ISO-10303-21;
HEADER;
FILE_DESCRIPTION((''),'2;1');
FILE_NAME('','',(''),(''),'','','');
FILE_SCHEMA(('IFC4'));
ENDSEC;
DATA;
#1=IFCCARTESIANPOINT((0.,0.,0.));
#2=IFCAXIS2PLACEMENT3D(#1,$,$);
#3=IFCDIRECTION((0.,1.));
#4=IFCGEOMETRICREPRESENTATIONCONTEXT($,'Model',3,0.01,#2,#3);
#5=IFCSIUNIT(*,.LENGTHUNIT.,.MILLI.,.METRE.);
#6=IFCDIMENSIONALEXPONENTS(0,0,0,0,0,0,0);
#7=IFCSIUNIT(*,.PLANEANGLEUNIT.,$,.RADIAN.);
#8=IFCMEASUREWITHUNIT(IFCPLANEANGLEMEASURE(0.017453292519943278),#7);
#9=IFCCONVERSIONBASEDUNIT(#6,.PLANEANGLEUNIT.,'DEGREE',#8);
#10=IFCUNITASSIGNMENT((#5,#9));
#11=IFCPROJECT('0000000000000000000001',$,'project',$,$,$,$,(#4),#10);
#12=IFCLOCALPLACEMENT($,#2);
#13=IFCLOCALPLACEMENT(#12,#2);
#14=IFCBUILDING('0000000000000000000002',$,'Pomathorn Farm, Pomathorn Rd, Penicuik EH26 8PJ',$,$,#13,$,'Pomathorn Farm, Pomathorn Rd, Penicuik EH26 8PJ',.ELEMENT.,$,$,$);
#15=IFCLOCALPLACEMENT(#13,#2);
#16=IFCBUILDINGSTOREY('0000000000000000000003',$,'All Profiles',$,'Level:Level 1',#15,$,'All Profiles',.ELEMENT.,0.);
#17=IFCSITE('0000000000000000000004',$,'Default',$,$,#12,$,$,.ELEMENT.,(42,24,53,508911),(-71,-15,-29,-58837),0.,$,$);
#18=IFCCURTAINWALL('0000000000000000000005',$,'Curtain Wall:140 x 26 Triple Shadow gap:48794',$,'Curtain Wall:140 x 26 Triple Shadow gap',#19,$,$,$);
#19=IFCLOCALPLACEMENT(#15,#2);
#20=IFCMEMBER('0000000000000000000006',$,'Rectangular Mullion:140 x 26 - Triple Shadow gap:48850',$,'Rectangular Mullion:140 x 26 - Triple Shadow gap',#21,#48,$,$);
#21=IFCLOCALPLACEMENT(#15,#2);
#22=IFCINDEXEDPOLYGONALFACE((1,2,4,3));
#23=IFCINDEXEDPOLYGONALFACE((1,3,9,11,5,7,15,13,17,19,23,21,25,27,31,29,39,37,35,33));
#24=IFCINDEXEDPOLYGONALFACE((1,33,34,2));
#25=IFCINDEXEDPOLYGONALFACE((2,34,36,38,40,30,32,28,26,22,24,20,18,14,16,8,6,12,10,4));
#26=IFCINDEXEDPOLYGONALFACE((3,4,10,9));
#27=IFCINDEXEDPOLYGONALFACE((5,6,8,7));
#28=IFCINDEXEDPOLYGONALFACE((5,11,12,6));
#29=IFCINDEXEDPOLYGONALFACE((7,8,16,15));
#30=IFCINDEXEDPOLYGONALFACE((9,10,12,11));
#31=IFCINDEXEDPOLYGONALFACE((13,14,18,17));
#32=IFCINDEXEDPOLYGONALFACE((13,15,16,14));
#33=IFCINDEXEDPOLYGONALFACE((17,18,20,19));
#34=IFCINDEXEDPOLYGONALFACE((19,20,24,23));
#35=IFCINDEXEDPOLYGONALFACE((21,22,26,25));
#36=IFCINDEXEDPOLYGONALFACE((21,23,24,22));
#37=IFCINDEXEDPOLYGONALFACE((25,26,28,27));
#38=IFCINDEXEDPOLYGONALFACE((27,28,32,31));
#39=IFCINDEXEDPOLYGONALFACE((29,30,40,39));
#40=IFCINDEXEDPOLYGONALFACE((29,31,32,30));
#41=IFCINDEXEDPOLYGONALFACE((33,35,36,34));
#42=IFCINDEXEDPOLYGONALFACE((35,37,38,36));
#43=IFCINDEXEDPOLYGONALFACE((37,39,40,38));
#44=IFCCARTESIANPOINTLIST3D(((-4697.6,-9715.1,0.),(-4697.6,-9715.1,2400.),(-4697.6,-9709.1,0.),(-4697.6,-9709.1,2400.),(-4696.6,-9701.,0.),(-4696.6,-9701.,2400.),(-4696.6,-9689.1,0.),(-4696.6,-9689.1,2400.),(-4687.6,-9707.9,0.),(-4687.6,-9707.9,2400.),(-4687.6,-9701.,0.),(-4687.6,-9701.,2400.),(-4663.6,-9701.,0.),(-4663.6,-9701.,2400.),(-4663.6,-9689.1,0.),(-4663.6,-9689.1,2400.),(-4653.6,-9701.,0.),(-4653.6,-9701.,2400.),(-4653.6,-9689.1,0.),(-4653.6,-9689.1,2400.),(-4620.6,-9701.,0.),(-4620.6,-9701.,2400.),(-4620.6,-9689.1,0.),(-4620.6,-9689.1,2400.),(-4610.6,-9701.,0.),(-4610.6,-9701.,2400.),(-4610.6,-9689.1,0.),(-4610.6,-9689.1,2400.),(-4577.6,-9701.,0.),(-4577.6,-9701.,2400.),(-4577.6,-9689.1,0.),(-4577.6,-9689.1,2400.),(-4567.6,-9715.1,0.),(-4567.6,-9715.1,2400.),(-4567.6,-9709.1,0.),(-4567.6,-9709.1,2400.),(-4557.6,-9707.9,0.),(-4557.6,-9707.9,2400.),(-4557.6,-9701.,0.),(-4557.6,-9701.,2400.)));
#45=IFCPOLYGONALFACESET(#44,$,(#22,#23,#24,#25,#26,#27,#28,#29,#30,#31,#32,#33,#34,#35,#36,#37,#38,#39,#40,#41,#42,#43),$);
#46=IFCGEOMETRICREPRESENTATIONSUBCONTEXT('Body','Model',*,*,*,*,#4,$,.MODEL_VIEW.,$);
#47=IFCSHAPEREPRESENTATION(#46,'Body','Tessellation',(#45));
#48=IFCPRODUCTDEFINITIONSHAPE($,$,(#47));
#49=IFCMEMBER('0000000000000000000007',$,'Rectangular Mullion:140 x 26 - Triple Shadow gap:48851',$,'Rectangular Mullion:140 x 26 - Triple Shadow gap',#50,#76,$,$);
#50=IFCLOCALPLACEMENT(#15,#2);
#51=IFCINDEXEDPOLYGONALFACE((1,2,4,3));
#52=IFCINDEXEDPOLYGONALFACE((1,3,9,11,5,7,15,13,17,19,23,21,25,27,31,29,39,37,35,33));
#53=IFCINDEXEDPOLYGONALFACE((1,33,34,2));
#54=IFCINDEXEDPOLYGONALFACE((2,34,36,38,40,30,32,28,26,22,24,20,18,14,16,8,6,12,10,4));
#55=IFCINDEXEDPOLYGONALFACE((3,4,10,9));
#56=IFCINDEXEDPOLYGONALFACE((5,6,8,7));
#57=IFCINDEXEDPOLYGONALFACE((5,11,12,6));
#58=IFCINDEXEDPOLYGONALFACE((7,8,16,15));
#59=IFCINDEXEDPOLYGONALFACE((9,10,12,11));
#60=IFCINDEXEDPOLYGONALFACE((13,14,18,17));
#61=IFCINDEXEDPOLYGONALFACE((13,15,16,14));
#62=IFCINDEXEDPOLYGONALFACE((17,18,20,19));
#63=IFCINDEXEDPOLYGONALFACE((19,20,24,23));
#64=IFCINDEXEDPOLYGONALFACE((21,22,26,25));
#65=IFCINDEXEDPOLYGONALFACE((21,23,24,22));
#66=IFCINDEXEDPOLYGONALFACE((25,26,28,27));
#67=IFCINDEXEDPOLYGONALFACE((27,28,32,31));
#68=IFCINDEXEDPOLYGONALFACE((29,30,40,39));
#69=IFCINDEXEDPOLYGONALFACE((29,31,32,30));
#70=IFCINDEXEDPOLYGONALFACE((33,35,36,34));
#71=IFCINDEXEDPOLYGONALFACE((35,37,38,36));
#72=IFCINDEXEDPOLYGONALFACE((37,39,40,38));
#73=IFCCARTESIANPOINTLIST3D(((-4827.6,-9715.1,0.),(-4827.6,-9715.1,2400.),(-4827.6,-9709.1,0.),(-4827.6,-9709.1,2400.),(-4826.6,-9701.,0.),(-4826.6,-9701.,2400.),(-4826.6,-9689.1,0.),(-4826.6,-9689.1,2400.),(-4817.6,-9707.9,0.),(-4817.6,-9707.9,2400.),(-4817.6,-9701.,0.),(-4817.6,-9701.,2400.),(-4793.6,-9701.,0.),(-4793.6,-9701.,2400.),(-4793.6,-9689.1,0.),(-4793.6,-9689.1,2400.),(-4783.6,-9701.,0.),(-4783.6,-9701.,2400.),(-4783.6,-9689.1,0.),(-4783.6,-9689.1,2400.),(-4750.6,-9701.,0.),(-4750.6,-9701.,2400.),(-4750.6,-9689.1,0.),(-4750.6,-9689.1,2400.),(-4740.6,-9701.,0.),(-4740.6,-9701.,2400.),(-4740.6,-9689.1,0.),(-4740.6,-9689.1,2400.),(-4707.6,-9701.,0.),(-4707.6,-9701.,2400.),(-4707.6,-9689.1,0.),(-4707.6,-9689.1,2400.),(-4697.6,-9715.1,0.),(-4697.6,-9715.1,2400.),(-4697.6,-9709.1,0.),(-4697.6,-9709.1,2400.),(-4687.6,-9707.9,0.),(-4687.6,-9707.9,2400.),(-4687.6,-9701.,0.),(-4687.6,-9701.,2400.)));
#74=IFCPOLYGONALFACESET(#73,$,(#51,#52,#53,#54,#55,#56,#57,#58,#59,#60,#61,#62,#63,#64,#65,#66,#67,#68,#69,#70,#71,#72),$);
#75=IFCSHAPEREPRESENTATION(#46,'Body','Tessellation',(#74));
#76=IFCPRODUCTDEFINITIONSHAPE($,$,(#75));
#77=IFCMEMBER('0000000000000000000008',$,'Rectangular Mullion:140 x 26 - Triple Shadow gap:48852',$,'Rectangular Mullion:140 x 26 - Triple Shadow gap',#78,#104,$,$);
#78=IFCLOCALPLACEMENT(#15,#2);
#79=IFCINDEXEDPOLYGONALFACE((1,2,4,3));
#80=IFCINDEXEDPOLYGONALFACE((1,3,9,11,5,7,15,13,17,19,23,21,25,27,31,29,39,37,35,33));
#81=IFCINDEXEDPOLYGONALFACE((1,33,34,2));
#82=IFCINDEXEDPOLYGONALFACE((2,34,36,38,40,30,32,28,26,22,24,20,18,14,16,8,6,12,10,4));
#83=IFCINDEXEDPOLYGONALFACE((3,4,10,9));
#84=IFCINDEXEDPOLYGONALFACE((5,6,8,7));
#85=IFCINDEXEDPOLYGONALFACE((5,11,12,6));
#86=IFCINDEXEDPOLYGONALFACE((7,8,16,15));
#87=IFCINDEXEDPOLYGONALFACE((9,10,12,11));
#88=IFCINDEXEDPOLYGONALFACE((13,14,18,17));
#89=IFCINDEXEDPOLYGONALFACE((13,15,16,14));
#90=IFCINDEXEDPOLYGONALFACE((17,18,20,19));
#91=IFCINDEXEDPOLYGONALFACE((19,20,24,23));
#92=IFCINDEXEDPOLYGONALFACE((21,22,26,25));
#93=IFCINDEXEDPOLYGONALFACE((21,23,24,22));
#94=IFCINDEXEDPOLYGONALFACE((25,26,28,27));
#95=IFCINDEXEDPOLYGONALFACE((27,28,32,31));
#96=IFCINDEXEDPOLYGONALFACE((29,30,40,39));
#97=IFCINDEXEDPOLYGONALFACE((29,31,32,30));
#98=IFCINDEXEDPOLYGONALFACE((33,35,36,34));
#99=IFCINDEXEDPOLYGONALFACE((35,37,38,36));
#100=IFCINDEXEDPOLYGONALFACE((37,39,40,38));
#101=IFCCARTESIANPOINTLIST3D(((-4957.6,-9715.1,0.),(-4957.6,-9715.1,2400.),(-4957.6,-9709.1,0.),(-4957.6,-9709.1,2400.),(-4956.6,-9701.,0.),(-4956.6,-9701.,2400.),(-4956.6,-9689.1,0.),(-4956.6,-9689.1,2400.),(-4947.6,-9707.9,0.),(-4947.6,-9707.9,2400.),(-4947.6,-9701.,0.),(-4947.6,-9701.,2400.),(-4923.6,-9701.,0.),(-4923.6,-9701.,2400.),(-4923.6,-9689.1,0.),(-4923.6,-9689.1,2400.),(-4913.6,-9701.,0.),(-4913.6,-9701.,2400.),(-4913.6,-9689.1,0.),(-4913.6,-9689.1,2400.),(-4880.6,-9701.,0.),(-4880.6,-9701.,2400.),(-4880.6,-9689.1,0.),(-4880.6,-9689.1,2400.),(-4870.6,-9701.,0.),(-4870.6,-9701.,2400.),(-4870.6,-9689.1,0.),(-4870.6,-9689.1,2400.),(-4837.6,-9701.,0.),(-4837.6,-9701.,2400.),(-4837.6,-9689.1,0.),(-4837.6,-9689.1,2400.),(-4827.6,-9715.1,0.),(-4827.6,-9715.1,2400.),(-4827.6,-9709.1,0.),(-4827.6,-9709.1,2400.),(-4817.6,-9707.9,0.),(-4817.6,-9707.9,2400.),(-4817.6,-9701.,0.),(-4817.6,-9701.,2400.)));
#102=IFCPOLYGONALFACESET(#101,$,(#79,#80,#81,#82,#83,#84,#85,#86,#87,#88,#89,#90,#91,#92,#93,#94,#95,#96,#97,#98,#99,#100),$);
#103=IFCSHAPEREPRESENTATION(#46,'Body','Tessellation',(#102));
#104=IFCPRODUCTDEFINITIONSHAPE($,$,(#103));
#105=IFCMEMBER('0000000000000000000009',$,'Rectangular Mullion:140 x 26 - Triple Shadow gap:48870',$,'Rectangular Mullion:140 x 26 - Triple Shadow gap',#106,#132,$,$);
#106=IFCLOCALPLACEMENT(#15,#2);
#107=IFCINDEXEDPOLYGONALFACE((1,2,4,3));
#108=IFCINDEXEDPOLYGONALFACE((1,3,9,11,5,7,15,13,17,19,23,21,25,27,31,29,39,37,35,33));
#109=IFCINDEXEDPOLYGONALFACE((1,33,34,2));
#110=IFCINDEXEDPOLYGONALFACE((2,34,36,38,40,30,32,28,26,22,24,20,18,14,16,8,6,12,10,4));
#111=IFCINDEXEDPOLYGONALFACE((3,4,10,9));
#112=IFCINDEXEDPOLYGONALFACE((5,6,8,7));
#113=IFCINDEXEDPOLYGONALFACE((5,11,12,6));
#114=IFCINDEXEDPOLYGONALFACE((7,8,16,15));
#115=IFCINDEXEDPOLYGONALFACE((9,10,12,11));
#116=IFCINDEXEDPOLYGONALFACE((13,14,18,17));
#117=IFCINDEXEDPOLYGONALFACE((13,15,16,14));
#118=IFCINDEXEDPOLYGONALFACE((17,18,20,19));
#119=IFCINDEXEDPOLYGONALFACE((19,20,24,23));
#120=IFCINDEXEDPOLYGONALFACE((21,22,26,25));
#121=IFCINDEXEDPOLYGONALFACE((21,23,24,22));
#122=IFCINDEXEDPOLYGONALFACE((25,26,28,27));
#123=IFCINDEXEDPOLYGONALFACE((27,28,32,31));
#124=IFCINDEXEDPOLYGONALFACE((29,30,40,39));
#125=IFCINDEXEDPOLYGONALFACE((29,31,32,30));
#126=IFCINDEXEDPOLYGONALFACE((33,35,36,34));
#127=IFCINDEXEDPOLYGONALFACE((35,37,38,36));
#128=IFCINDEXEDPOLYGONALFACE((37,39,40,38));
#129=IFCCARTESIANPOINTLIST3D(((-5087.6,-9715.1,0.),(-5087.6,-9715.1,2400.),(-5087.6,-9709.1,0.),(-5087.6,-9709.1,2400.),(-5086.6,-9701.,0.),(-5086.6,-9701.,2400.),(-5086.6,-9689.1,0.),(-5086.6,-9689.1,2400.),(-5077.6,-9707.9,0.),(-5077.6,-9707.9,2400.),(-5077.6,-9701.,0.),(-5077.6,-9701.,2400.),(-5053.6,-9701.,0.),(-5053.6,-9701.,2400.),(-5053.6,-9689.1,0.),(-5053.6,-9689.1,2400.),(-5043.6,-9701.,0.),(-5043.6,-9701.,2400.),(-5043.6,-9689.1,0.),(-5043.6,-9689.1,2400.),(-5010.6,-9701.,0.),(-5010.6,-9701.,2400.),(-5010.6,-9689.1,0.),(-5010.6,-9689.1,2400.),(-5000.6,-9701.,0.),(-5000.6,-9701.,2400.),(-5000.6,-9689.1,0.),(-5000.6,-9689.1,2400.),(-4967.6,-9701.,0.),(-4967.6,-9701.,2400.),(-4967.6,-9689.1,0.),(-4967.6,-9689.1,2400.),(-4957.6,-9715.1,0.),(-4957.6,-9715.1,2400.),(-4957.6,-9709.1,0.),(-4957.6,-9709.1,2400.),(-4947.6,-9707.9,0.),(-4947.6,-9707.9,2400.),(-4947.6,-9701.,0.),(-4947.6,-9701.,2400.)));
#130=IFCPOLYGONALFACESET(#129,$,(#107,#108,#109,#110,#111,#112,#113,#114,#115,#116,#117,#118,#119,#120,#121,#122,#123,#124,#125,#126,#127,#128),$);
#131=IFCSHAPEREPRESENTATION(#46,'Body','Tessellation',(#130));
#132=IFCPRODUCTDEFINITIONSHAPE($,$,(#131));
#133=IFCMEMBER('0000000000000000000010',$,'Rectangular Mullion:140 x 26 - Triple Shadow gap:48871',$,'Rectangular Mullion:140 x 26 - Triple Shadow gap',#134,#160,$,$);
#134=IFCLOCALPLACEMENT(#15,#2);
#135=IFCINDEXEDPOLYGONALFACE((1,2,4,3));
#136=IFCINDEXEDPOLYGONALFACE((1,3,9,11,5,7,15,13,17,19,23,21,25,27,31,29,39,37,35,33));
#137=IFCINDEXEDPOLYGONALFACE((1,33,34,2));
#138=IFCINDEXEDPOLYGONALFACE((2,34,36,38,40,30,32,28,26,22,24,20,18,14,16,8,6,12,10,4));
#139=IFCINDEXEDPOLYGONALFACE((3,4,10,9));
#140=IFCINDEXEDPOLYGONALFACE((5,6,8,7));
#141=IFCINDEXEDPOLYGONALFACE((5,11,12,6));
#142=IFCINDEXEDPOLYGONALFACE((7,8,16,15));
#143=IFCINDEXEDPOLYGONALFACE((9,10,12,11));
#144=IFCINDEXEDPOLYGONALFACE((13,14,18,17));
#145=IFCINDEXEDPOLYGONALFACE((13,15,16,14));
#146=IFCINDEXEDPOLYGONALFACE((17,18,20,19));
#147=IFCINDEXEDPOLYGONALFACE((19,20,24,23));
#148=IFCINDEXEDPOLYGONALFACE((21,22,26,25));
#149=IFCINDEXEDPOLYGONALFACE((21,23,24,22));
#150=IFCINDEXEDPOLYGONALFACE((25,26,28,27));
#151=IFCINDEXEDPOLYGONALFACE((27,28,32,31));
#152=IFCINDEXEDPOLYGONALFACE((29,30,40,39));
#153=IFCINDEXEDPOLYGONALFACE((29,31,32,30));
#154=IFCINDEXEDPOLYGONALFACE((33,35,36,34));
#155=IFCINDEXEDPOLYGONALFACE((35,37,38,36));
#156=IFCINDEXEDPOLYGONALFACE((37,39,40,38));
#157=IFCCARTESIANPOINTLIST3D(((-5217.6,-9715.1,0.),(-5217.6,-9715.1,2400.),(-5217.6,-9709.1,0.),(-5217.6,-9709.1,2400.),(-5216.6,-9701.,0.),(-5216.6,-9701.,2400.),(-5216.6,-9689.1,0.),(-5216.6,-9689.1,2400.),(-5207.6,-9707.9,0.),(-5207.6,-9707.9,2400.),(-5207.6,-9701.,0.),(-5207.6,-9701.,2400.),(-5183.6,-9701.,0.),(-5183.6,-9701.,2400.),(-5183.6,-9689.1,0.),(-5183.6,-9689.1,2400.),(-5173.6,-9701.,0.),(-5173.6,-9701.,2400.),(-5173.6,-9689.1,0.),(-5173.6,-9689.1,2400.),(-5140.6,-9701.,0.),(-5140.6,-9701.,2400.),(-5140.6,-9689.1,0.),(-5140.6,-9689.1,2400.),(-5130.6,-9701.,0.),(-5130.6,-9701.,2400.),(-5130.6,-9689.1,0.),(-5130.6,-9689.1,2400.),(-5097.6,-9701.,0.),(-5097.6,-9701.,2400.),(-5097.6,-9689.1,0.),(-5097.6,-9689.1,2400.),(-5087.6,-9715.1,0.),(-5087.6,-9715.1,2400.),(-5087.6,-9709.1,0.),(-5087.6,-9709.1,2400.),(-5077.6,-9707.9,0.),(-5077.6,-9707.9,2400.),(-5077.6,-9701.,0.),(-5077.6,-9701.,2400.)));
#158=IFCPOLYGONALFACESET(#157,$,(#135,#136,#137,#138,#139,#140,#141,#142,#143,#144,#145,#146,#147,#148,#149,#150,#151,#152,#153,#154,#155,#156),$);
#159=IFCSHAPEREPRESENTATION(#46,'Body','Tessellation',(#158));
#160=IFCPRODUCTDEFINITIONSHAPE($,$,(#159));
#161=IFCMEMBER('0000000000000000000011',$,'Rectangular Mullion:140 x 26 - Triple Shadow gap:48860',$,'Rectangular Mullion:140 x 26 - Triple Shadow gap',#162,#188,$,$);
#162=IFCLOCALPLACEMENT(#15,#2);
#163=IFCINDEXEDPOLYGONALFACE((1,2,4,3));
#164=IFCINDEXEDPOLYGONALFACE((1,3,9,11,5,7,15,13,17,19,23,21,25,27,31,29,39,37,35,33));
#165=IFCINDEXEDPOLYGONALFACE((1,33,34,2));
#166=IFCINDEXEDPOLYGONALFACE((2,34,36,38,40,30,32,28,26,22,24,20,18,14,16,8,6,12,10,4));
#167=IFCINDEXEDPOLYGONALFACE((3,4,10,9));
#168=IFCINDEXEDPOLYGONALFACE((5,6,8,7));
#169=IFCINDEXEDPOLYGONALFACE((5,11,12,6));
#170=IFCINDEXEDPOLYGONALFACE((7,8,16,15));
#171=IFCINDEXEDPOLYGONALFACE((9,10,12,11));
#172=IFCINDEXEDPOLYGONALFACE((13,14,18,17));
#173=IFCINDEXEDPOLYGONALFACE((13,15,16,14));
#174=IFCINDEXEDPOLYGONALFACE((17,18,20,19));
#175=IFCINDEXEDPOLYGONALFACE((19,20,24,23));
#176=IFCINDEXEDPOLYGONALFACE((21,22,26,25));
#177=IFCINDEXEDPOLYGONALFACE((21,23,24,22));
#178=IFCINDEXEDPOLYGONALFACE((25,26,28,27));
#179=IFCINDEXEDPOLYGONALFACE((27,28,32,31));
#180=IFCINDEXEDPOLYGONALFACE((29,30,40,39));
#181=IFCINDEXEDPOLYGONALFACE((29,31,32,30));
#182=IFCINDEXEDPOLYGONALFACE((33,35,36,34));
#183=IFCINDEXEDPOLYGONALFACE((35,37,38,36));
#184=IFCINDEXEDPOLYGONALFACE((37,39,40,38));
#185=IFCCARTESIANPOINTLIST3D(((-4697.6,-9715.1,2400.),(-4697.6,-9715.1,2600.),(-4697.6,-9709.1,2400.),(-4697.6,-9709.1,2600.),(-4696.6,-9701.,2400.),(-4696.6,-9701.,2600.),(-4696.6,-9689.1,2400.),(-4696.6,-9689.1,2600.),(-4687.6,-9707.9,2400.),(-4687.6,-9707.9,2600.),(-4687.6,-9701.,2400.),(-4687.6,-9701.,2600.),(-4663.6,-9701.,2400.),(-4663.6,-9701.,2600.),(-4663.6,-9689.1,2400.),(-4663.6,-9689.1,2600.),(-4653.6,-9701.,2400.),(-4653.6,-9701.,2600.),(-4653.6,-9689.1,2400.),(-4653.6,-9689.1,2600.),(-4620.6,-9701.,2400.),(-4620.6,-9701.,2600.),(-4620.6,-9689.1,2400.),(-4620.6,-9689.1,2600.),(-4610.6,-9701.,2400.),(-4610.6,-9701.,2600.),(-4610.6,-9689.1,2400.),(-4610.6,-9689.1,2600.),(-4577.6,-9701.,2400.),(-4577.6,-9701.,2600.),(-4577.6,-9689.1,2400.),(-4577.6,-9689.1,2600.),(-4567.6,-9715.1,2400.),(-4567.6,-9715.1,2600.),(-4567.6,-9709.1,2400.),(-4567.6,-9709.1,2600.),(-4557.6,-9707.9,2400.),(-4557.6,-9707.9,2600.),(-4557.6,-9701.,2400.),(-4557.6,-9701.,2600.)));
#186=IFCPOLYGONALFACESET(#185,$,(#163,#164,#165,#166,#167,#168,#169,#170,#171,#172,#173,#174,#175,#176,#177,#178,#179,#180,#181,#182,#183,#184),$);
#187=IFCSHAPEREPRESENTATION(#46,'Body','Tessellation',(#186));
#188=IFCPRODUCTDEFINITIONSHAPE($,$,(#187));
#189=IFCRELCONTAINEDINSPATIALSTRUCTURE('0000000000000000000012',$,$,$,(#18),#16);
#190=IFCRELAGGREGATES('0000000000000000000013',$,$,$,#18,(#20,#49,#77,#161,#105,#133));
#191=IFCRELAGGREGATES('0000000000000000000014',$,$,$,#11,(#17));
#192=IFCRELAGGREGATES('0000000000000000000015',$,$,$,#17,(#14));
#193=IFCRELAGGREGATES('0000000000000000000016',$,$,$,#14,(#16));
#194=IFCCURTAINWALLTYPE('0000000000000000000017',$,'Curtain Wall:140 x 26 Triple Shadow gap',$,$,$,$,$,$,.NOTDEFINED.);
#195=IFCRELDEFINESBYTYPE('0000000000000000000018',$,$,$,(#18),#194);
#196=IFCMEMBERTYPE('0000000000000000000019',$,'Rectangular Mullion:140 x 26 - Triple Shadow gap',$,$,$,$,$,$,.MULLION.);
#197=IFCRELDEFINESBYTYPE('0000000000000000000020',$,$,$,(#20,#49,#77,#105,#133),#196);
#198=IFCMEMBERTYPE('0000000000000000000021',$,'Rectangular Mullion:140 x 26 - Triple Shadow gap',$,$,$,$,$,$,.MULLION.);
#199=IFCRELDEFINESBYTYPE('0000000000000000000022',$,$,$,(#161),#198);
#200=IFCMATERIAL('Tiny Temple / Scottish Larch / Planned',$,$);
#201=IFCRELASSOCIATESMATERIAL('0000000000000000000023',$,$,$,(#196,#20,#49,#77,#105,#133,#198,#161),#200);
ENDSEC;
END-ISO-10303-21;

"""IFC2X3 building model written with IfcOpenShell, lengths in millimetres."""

from ifc_helpers import new_model, entity, si_unit, converted_unit, direction, frame, origin, place, context, subcontext, project, spatial, polyline, outline, extrude, source, transform, mapped, material, type_object, type_shapes, element, aggregate, save


model = new_model("IFC2X3")

# Units and contexts
model_context = context("Model", 3, precision=0.01, world=origin(), true_north=direction((0.0, 1.0)))
body_context = subcontext(model_context, "Body", "Model", "MODEL_VIEW")
ifc_project = project(units=[si_unit("LENGTHUNIT", "METRE", prefix="MILLI"), converted_unit("PLANEANGLEUNIT", "DEGREE", entity("IfcPlaneAngleMeasure", 0.017453292519943278), si_unit("PLANEANGLEUNIT", "RADIAN"), dimensions=[0, 0, 0, 0, 0, 0, 0])], contexts=[model_context])

# Site, building, storey
site_placement = place(None, origin())
site = spatial("IfcSite", under=ifc_project, at=site_placement, Name="Default", CompositionType="ELEMENT", RefLatitude=(42, 24, 53, 508911), RefLongitude=(-71, -15, -29, -58837), RefElevation=0.0)
building_placement = place(site_placement, origin())
building = spatial("IfcBuilding", under=site, at=building_placement, Name="Pomathorn Farm, Pomathorn Rd, Penicuik EH26 8PJ", LongName="Pomathorn Farm, Pomathorn Rd, Penicuik EH26 8PJ", CompositionType="ELEMENT")
storey_placement = place(building_placement, origin())
storey = spatial("IfcBuildingStorey", under=building, at=storey_placement, Name="All Profiles", ObjectType="Level:Level 1", LongName="All Profiles", CompositionType="ELEMENT", Elevation=0.0)

# Curtain wall, members
ifc_material = material(Name="Tiny Temple / Scottish Larch / Planned")
curtain_wall_type_1 = type_object("IfcCurtainWallType", Name="Curtain Wall:140 x 26 Triple Shadow gap", PredefinedType="NOTDEFINED")
curtain_wall_1_placement = place(storey_placement, origin())
curtain_wall_1 = element("IfcCurtainWall", 1, at=curtain_wall_1_placement, inside=storey, type_object=curtain_wall_type_1, Name="Curtain Wall:140 x 26 Triple Shadow gap:48794", ObjectType="Curtain Wall:140 x 26 Triple Shadow gap")
member_type_1 = type_object("IfcMemberType", Name="Rectangular Mullion:140 x 26 - Triple Shadow gap", PredefinedType="MULLION", material=ifc_material)
shared_shape_1 = source(origin(), body_context, "Body", "SweptSolid", [
    extrude(outline(polyline([(-64.9, -0.9), (-65.6, -6.8), (63.4, -22.7), (64.1, -16.7), (74.2, -16.7), (75.1, -9.8), (55.2, -7.4), (56.7, 4.3), (23.9, 8.4), (22.5, -3.4), (12.5, -2.2), (14.0, 9.6), (-18.8, 13.6), (-20.2, 1.9), (-30.1, 3.1), (-28.7, 14.8), (-61.5, 18.8), (-62.9, 7.1), (-54.0, 6.0), (-54.8, -0.9), (-64.9, -0.9)])), frame((-75.7, -14.8, -2400.0), z_axis=(0.0, 0.0, -1.0), x_axis=(0.992546, -0.121869, 0.0)), (0.0, 0.0, -1.0), 2400.0),
])
type_shapes(member_type_1, [shared_shape_1])
member_1_placement = place(curtain_wall_1_placement, frame((-4557.6, -9715.1, 0.0), z_axis=(0.0, 0.0, -1.0), x_axis=(1.0, 0.0, 0.0)))
member_1 = element("IfcMember", 2, at=member_1_placement, type_object=member_type_1, material=ifc_material, Name="Rectangular Mullion:140 x 26 - Triple Shadow gap:48850", ObjectType="Rectangular Mullion:140 x 26 - Triple Shadow gap", context=body_context, shape_type="MappedRepresentation", body=[
    mapped(shared_shape_1, transform((0.0, 0.0, 0.0), scale=1.0)),
])
member_2_placement = place(curtain_wall_1_placement, frame((-4687.6, -9715.1, 0.0), z_axis=(0.0, 0.0, -1.0), x_axis=(1.0, 0.0, 0.0)))
member_2 = element("IfcMember", 3, at=member_2_placement, type_object=member_type_1, material=ifc_material, Name="Rectangular Mullion:140 x 26 - Triple Shadow gap:48851", ObjectType="Rectangular Mullion:140 x 26 - Triple Shadow gap", context=body_context, shape_type="MappedRepresentation", body=[
    mapped(shared_shape_1, transform((0.0, 0.0, 0.0), scale=1.0)),
])
member_3_placement = place(curtain_wall_1_placement, frame((-4817.6, -9715.1, 0.0), z_axis=(0.0, 0.0, -1.0), x_axis=(1.0, 0.0, 0.0)))
member_3 = element("IfcMember", 4, at=member_3_placement, type_object=member_type_1, material=ifc_material, Name="Rectangular Mullion:140 x 26 - Triple Shadow gap:48852", ObjectType="Rectangular Mullion:140 x 26 - Triple Shadow gap", context=body_context, shape_type="MappedRepresentation", body=[
    mapped(shared_shape_1, transform((0.0, 0.0, 0.0), scale=1.0)),
])
member_4_placement = place(curtain_wall_1_placement, frame((-4947.6, -9715.1, 0.0), z_axis=(0.0, 0.0, -1.0), x_axis=(1.0, 0.0, 0.0)))
member_4 = element("IfcMember", 5, at=member_4_placement, type_object=member_type_1, material=ifc_material, Name="Rectangular Mullion:140 x 26 - Triple Shadow gap:48870", ObjectType="Rectangular Mullion:140 x 26 - Triple Shadow gap", context=body_context, shape_type="MappedRepresentation", body=[
    mapped(shared_shape_1, transform((0.0, 0.0, 0.0), scale=1.0)),
])
member_5_placement = place(curtain_wall_1_placement, frame((-5077.6, -9715.1, 0.0), z_axis=(0.0, 0.0, -1.0), x_axis=(1.0, 0.0, 0.0)))
member_5 = element("IfcMember", 6, at=member_5_placement, type_object=member_type_1, material=ifc_material, Name="Rectangular Mullion:140 x 26 - Triple Shadow gap:48871", ObjectType="Rectangular Mullion:140 x 26 - Triple Shadow gap", context=body_context, shape_type="MappedRepresentation", body=[
    mapped(shared_shape_1, transform((0.0, 0.0, 0.0), scale=1.0)),
])
member_type_2 = type_object("IfcMemberType", Name="Rectangular Mullion:140 x 26 - Triple Shadow gap", PredefinedType="MULLION", material=ifc_material)
shared_shape_2 = source(origin(), body_context, "Body", "SweptSolid", [
    extrude(outline(polyline([(-64.9, -0.9), (-65.6, -6.8), (63.4, -22.7), (64.1, -16.7), (74.2, -16.7), (75.1, -9.8), (55.2, -7.4), (56.7, 4.3), (23.9, 8.4), (22.5, -3.4), (12.5, -2.2), (14.0, 9.6), (-18.8, 13.6), (-20.2, 1.9), (-30.1, 3.1), (-28.7, 14.8), (-61.5, 18.8), (-62.9, 7.1), (-54.0, 6.0), (-54.8, -0.9), (-64.9, -0.9)])), frame((-75.7, -14.8, -200.0), z_axis=(0.0, 0.0, -1.0), x_axis=(0.992546, -0.121869, 0.0)), (0.0, 0.0, -1.0), 200.0),
])
type_shapes(member_type_2, [shared_shape_2])
member_6_placement = place(curtain_wall_1_placement, frame((-4557.6, -9715.1, 2400.0), z_axis=(0.0, 0.0, -1.0), x_axis=(1.0, 0.0, 0.0)))
member_6 = element("IfcMember", 7, at=member_6_placement, type_object=member_type_2, material=ifc_material, Name="Rectangular Mullion:140 x 26 - Triple Shadow gap:48860", ObjectType="Rectangular Mullion:140 x 26 - Triple Shadow gap", context=body_context, shape_type="MappedRepresentation", body=[
    mapped(shared_shape_2, transform((0.0, 0.0, 0.0), scale=1.0)),
])
aggregate(curtain_wall_1, [member_1, member_2, member_3, member_6, member_4, member_5])

save(model, "model.ifc")
